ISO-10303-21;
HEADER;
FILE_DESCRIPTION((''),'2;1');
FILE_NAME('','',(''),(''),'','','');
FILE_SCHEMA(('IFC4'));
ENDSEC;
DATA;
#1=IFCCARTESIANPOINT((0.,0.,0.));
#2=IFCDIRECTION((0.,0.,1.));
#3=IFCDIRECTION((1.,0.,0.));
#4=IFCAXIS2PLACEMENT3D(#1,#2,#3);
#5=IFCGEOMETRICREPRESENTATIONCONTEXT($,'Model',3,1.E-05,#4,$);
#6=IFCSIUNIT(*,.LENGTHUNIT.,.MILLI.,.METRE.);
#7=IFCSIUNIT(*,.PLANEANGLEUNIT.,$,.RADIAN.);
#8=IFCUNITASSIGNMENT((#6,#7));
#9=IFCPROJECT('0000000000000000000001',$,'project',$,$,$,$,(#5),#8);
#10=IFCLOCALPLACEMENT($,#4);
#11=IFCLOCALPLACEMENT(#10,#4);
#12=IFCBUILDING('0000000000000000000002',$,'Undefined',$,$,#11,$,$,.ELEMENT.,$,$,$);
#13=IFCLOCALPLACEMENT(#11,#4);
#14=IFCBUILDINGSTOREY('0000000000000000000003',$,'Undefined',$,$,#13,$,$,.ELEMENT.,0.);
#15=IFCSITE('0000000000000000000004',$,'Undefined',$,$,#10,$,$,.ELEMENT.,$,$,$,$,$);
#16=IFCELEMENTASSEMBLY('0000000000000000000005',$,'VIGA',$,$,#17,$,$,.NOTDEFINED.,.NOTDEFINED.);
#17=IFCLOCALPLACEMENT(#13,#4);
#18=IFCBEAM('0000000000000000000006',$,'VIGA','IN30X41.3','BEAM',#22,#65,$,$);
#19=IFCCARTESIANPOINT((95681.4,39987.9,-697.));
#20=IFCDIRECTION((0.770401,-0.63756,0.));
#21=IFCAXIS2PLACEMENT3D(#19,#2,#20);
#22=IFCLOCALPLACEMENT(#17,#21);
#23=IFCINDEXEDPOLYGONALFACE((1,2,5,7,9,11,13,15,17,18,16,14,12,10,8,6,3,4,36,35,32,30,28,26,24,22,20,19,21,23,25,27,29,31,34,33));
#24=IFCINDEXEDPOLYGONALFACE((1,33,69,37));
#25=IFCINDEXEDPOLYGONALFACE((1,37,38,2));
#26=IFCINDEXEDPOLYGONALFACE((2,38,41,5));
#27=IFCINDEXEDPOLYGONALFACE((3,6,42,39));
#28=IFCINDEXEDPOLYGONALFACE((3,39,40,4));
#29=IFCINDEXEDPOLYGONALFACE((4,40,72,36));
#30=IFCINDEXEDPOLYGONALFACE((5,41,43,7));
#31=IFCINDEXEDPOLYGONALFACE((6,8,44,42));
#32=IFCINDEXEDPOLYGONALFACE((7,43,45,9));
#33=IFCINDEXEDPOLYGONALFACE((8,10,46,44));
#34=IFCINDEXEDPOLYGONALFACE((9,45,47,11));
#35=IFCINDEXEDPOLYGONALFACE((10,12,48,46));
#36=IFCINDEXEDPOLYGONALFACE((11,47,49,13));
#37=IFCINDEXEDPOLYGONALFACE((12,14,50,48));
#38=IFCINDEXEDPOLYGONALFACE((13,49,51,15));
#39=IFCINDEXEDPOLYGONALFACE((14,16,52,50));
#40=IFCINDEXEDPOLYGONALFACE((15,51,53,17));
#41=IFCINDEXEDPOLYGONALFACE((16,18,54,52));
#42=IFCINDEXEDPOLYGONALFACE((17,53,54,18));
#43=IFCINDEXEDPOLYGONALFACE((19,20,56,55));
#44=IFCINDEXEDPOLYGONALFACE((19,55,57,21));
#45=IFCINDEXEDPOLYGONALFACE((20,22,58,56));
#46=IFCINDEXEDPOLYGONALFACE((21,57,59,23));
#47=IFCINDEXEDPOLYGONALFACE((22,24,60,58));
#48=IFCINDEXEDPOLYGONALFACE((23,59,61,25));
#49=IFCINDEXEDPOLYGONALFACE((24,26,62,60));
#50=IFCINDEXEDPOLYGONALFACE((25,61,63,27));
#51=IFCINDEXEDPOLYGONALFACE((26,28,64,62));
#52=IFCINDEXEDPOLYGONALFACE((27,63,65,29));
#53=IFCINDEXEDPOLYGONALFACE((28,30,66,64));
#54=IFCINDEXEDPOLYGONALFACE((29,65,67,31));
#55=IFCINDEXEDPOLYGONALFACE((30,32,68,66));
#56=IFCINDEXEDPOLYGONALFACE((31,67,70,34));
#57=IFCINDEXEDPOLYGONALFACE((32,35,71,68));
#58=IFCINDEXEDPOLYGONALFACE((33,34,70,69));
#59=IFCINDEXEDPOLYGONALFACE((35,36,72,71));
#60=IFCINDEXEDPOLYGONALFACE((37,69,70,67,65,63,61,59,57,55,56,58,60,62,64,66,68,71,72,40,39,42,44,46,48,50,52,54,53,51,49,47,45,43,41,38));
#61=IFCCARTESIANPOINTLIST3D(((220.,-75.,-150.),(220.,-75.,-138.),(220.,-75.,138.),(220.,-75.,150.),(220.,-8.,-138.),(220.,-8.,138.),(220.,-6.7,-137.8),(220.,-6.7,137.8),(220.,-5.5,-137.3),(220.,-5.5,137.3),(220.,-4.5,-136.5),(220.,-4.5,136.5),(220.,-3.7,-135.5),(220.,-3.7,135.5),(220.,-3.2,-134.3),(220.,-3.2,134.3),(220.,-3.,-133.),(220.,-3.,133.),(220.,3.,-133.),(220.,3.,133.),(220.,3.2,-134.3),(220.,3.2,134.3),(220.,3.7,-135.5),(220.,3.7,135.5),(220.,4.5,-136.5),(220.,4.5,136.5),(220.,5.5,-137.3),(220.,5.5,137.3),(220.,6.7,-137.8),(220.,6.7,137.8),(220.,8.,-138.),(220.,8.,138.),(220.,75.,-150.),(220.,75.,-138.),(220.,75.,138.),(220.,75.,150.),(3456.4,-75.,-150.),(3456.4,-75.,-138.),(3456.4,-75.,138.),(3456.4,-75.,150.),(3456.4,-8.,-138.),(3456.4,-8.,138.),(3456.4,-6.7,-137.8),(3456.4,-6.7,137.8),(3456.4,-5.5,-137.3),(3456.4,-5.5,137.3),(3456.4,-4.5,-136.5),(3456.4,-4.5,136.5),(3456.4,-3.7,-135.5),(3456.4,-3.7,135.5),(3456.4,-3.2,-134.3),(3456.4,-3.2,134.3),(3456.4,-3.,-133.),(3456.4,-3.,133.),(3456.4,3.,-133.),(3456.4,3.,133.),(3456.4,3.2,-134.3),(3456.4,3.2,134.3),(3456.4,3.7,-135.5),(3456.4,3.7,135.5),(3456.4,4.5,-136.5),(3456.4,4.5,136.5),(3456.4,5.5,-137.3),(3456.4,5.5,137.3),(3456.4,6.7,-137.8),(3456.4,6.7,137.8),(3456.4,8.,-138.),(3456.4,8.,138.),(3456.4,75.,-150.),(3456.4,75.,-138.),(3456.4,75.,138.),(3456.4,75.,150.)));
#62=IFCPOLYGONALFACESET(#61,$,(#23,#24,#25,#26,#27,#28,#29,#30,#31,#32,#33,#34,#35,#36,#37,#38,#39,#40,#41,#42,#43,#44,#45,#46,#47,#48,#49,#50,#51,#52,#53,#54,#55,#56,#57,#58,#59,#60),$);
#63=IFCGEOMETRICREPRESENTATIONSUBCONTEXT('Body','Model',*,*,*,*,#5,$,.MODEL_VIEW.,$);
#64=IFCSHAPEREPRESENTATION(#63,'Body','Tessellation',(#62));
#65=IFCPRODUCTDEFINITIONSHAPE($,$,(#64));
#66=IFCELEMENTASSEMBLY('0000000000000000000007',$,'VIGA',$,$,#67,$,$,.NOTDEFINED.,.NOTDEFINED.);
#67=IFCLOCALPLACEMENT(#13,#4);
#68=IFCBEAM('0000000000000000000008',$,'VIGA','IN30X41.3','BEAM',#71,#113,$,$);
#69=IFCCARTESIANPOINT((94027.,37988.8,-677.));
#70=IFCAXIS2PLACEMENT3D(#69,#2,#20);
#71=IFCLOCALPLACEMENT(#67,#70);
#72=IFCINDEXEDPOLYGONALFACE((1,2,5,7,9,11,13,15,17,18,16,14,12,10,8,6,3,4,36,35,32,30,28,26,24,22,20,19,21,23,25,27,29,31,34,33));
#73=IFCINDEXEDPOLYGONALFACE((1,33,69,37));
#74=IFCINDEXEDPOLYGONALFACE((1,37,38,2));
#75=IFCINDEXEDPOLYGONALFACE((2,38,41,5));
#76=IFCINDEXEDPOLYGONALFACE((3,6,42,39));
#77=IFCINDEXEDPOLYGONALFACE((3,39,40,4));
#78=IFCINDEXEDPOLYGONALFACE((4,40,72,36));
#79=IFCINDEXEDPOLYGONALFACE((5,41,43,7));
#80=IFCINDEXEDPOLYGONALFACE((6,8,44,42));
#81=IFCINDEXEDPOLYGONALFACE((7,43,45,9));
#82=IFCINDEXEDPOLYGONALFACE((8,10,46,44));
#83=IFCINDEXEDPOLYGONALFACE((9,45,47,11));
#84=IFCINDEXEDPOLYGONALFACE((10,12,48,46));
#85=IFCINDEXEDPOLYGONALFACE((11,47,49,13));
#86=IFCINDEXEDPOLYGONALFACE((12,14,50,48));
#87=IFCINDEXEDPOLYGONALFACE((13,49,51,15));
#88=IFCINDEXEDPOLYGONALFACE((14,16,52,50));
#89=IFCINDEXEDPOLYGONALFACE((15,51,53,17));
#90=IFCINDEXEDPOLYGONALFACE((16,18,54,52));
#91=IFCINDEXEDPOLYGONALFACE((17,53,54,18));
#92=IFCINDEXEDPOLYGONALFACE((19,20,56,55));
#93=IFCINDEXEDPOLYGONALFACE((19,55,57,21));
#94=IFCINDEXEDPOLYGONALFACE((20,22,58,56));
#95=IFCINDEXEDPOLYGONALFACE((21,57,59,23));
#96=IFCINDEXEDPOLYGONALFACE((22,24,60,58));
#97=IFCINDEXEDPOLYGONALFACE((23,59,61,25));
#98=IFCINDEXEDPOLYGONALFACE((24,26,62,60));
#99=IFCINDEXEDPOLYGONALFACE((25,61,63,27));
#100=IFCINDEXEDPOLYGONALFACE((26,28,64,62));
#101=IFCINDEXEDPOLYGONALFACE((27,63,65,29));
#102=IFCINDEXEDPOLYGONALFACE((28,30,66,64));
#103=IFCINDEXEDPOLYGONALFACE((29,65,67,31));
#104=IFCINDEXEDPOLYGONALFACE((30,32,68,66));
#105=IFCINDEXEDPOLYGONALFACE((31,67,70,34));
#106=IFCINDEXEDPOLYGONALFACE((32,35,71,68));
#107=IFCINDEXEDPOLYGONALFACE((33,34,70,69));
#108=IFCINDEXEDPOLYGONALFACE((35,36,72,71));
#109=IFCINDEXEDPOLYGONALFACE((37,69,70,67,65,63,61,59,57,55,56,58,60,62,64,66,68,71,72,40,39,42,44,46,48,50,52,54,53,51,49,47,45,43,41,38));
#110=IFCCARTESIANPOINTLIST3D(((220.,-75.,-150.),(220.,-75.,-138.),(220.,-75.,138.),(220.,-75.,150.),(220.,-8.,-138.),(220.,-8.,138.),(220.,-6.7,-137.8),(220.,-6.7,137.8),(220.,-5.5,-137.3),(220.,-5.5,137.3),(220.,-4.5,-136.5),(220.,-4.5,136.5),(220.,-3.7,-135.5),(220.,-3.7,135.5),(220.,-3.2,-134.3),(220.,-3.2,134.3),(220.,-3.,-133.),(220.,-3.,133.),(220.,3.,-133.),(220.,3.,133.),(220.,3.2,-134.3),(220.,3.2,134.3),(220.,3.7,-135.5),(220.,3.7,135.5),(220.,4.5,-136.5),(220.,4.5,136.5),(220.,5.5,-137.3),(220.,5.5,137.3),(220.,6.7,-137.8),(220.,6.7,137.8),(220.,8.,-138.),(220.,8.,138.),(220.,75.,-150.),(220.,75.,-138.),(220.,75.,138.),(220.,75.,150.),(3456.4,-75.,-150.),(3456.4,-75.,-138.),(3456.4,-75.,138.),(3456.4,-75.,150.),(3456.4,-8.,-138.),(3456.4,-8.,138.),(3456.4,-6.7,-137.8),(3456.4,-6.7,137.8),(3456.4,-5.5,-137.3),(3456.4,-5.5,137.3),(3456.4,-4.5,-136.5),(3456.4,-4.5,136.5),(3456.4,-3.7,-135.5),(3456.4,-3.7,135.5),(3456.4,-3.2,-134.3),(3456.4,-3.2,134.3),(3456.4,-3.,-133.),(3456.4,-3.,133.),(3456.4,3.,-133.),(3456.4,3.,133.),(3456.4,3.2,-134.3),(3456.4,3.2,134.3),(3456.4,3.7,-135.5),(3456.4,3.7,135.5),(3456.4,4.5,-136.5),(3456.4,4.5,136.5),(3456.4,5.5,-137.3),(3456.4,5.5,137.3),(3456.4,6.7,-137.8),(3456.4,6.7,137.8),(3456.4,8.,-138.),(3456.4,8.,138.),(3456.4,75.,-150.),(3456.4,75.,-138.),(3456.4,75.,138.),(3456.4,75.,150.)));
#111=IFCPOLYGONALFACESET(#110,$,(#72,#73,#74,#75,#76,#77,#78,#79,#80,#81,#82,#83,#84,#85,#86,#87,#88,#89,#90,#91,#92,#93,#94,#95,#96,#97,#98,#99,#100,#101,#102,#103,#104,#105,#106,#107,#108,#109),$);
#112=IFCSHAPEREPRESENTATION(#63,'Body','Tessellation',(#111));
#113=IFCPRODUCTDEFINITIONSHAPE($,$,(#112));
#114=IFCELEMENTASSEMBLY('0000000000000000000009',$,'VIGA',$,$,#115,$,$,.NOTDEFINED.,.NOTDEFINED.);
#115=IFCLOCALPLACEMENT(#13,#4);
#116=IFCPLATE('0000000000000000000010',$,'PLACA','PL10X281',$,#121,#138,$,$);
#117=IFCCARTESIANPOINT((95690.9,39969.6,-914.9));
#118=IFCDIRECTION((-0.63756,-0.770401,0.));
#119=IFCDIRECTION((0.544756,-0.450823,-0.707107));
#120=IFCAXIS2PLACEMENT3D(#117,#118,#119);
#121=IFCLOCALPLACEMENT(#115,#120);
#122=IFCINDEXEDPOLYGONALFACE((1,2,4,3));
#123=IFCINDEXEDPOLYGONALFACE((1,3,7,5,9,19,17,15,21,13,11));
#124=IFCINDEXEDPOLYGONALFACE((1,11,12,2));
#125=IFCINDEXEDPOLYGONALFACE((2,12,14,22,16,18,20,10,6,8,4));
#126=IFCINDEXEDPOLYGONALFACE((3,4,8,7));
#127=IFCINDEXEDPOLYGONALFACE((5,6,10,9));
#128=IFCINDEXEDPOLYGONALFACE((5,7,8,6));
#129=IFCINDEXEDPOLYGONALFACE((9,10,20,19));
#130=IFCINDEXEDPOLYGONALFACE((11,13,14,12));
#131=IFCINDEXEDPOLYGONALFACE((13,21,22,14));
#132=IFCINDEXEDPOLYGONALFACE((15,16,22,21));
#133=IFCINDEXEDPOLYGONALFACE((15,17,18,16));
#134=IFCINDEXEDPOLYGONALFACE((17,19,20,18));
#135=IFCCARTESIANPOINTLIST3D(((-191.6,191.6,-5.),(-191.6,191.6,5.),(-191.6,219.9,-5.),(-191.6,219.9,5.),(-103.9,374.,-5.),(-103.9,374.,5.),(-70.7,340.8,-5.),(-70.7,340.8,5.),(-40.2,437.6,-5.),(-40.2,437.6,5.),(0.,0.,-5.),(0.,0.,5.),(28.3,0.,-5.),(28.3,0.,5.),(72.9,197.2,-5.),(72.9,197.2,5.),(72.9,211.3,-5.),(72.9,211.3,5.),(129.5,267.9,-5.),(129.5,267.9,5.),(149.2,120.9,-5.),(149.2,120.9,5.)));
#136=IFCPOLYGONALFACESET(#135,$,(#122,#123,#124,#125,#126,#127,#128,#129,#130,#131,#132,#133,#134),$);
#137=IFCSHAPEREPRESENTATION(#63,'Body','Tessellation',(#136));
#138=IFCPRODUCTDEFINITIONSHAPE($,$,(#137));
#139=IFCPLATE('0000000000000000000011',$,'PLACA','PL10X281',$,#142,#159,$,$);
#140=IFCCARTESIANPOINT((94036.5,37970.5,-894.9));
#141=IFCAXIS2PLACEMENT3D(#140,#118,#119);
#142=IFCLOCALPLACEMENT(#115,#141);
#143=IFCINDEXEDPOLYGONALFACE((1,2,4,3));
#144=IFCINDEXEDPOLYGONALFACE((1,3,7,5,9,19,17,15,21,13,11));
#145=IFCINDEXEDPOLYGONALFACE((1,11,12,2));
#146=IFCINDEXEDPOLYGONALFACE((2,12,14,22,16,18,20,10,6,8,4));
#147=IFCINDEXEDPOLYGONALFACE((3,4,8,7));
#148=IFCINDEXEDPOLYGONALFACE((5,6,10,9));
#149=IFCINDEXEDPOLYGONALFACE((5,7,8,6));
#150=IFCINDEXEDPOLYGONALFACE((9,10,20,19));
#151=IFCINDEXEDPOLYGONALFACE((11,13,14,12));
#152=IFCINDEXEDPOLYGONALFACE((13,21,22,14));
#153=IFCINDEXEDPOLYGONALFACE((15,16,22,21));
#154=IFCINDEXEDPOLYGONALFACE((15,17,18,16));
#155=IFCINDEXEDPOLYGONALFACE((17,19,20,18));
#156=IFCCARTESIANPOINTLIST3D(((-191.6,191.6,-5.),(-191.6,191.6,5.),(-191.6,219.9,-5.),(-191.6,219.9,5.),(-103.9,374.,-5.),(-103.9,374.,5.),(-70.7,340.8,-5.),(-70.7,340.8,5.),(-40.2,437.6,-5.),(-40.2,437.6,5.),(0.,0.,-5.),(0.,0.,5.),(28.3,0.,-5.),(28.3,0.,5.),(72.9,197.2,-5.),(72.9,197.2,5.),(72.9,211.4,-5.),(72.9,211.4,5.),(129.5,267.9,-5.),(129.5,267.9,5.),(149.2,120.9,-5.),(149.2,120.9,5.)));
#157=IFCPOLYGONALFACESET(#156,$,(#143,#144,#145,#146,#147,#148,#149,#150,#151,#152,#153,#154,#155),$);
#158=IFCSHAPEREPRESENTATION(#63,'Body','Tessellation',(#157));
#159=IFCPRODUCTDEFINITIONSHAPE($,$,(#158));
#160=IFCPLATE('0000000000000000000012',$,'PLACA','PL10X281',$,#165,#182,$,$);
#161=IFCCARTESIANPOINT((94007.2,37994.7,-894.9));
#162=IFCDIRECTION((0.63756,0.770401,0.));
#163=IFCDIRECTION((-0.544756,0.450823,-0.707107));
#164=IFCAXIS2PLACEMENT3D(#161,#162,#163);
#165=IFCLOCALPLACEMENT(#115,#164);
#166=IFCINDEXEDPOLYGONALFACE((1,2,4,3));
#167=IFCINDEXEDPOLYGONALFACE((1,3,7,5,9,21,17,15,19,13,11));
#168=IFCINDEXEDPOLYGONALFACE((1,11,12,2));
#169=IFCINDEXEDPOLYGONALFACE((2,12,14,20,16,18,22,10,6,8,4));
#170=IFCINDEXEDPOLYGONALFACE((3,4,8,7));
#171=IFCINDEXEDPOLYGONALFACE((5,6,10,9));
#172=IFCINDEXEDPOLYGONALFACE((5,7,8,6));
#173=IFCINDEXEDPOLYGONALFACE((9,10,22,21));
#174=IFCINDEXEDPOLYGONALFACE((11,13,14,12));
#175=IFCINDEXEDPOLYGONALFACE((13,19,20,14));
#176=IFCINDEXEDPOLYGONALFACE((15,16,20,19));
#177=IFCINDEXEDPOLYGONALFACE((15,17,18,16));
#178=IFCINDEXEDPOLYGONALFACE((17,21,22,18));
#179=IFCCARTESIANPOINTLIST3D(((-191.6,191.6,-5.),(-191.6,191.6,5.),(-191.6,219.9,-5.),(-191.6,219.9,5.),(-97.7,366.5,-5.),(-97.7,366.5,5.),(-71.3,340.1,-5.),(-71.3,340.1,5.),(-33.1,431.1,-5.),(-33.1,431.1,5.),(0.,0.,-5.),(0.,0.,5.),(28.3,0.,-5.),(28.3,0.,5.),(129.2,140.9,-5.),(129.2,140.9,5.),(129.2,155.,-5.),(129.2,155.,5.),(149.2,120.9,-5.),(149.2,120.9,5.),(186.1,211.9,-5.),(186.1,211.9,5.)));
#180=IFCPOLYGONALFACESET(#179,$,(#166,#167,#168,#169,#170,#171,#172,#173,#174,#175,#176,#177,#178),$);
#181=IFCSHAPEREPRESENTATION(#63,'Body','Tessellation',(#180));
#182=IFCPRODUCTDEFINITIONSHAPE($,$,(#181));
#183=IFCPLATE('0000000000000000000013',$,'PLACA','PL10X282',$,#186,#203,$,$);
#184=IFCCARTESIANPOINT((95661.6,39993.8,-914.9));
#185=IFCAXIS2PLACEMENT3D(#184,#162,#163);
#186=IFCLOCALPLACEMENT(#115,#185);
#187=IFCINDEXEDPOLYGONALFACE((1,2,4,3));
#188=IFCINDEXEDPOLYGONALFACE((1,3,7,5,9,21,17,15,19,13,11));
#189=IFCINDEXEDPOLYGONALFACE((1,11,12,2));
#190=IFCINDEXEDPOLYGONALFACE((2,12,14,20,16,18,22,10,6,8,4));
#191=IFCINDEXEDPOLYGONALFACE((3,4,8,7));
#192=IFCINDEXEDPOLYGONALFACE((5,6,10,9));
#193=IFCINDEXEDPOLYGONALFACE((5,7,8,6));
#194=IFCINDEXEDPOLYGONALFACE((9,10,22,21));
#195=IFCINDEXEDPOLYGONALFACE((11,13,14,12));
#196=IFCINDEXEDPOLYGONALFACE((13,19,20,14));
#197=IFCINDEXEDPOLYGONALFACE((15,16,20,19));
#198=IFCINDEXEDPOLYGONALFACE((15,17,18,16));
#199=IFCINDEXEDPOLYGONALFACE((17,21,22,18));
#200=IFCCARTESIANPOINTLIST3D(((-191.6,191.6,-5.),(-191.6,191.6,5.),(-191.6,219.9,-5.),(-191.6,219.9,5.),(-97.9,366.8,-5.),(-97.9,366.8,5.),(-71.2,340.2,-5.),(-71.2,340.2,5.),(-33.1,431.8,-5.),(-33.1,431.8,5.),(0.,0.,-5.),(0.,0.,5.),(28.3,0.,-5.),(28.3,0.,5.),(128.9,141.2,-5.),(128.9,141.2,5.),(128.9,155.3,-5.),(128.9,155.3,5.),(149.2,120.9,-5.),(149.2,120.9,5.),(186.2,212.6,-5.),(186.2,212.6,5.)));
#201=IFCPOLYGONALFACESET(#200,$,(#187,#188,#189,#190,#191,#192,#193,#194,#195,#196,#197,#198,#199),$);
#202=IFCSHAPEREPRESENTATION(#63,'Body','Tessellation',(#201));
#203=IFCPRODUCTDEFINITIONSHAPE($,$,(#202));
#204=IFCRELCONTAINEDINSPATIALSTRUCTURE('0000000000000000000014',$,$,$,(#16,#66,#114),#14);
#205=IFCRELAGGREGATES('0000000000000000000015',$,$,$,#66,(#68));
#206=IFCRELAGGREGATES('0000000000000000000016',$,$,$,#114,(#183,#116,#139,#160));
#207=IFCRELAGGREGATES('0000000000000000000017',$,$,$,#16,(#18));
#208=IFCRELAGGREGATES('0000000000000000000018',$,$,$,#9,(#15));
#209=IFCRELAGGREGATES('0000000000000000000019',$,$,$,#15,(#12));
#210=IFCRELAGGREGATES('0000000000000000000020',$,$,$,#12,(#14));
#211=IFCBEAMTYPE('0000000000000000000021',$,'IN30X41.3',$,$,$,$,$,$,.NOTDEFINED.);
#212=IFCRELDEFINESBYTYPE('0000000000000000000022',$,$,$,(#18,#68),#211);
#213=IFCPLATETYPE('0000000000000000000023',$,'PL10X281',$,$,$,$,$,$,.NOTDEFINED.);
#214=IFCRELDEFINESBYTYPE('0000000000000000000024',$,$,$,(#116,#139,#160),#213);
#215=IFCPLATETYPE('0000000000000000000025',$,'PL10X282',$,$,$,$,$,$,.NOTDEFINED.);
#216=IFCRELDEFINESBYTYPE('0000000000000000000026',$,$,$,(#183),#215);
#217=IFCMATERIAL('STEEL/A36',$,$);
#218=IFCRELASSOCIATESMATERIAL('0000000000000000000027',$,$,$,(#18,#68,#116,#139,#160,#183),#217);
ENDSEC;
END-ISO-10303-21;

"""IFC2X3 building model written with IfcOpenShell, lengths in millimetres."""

from ifc_helpers import new_model, si_unit, frame, origin_with_axes, origin_2d_with_axis, place, context, subcontext, project, spatial, polyline, i_section, outline, extrude, clip, halfspace, material, type_object, element, aggregate, save


model = new_model("IFC2X3")

# Units and contexts
model_context = context("Model", 3, precision=1e-05, world=origin_with_axes())
body_context = subcontext(model_context, "Body", "Model", "MODEL_VIEW")
ifc_project = project(units=[si_unit("LENGTHUNIT", "METRE", prefix="MILLI"), si_unit("PLANEANGLEUNIT", "RADIAN")], contexts=[model_context])

# Site, building, storey
site_placement = place(None, origin_with_axes())
site = spatial("IfcSite", under=ifc_project, at=site_placement, Name="Undefined", CompositionType="ELEMENT")
building_placement = place(site_placement, origin_with_axes())
building = spatial("IfcBuilding", under=site, at=building_placement, Name="Undefined", CompositionType="ELEMENT")
storey_placement = place(building_placement, origin_with_axes())
storey = spatial("IfcBuildingStorey", under=building, at=storey_placement, Name="Undefined", CompositionType="ELEMENT", Elevation=0.0)

# Shared definitions
ifc_material_1 = material(Name="STEEL/A36")

# Element assemblies, beams
assembly_1_placement = place(storey_placement, origin_with_axes())
assembly_1 = element("IfcElementAssembly", 1, at=assembly_1_placement, inside=storey, Name="VIGA", AssemblyPlace="NOTDEFINED", PredefinedType="NOTDEFINED")
beam_type_1 = type_object("IfcBeamType", Name="IN30X41.3", PredefinedType="NOTDEFINED")
beam_1_placement = place(assembly_1_placement, frame((95681.4, 39987.9, -697.0), z_axis=(0.0, 0.0, 1.0), x_axis=(0.770401, -0.63756, 0.0)))
beam_1 = element("IfcBeam", 2, at=beam_1_placement, type_object=beam_type_1, material=ifc_material_1, Name="VIGA", Description="IN30X41.3", ObjectType="BEAM", context=body_context, shape_type="Clipping", body=[
    clip(extrude(i_section(OverallWidth=150.0, OverallDepth=300.0, WebThickness=6.0, FlangeThickness=12.0, FilletRadius=5.0, at=origin_2d_with_axis()), frame((3456.4, 0.0, 0.0), z_axis=(-1.0, 0.0, 0.0), x_axis=(0.0, -1.0, 0.0)), (0.0, 0.0, 1.0), 3456.4), halfspace(frame((220.0, 0.0, 250.0), z_axis=(-1.0, 0.0, 0.0), x_axis=(0.0, -1.0, 0.0)), False)),
])
assembly_2_placement = place(storey_placement, origin_with_axes())
assembly_2 = element("IfcElementAssembly", 3, at=assembly_2_placement, inside=storey, Name="VIGA", AssemblyPlace="NOTDEFINED", PredefinedType="NOTDEFINED")
beam_2_placement = place(assembly_2_placement, frame((94027.0, 37988.8, -677.0), z_axis=(0.0, 0.0, 1.0), x_axis=(0.770401, -0.63756, 0.0)))
beam_2 = element("IfcBeam", 4, at=beam_2_placement, type_object=beam_type_1, material=ifc_material_1, Name="VIGA", Description="IN30X41.3", ObjectType="BEAM", context=body_context, shape_type="Clipping", body=[
    clip(extrude(i_section(OverallWidth=150.0, OverallDepth=300.0, WebThickness=6.0, FlangeThickness=12.0, FilletRadius=5.0, at=origin_2d_with_axis()), frame((3456.4, 0.0, 0.0), z_axis=(-1.0, 0.0, 0.0), x_axis=(0.0, -1.0, 0.0)), (0.0, 0.0, 1.0), 3456.4), halfspace(frame((220.0, 0.0, 250.0), z_axis=(-1.0, 0.0, 0.0), x_axis=(0.0, -1.0, 0.0)), False)),
])
aggregate(assembly_2, [beam_2])

# Element assembly
assembly_3_placement = place(storey_placement, origin_with_axes())
assembly_3 = element("IfcElementAssembly", 5, at=assembly_3_placement, inside=storey, Name="VIGA", AssemblyPlace="NOTDEFINED", PredefinedType="NOTDEFINED")

# Plates
plate_type_1 = type_object("IfcPlateType", Name="PL10X281", PredefinedType="NOTDEFINED")
plate_1_placement = place(assembly_3_placement, frame((95690.9, 39969.6, -914.9), z_axis=(-0.63756, -0.770401, 0.0), x_axis=(0.544756, -0.450823, -0.707107)))
plate_1 = element("IfcPlate", 6, at=plate_1_placement, type_object=plate_type_1, material=ifc_material_1, Name="PLACA", Description="PL10X281", context=body_context, shape_type="SweptSolid", body=[
    extrude(outline(polyline([(0.0, 0.0), (28.3, 0.0), (149.2, 120.9), (72.9, 197.2), (72.9, 211.3), (129.5, 267.9), (-40.2, 437.6), (-103.9, 374.0), (-70.7, 340.8), (-191.6, 219.9), (-191.6, 191.6), (0.0, 0.0)])), frame((0.0, 0.0, -5.0), z_axis=(0.0, 0.0, 1.0), x_axis=(1.0, 0.0, 0.0)), (0.0, 0.0, 1.0), 10.0),
])
plate_2_placement = place(assembly_3_placement, frame((94036.5, 37970.5, -894.9), z_axis=(-0.63756, -0.770401, 0.0), x_axis=(0.544756, -0.450823, -0.707107)))
plate_2 = element("IfcPlate", 7, at=plate_2_placement, type_object=plate_type_1, material=ifc_material_1, Name="PLACA", Description="PL10X281", context=body_context, shape_type="SweptSolid", body=[
    extrude(outline(polyline([(0.0, 0.0), (28.3, 0.0), (149.2, 120.9), (72.9, 197.2), (72.9, 211.4), (129.5, 267.9), (-40.2, 437.6), (-103.9, 374.0), (-70.7, 340.8), (-191.6, 219.9), (-191.6, 191.6), (0.0, 0.0)])), frame((0.0, 0.0, -5.0), z_axis=(0.0, 0.0, 1.0), x_axis=(1.0, 0.0, 0.0)), (0.0, 0.0, 1.0), 10.0),
])
plate_3_placement = place(assembly_3_placement, frame((94007.2, 37994.7, -894.9), z_axis=(0.63756, 0.770401, 0.0), x_axis=(-0.544756, 0.450823, -0.707107)))
plate_3 = element("IfcPlate", 8, at=plate_3_placement, type_object=plate_type_1, material=ifc_material_1, Name="PLACA", Description="PL10X281", context=body_context, shape_type="SweptSolid", body=[
    extrude(outline(polyline([(0.0, 0.0), (28.3, 0.0), (149.2, 120.9), (129.2, 140.9), (129.2, 155.0), (186.1, 211.9), (-33.1, 431.1), (-97.7, 366.5), (-71.3, 340.1), (-191.6, 219.9), (-191.6, 191.6), (0.0, 0.0)])), frame((0.0, 0.0, -5.0), z_axis=(0.0, 0.0, 1.0), x_axis=(1.0, 0.0, 0.0)), (0.0, 0.0, 1.0), 10.0),
])
plate_type_2 = type_object("IfcPlateType", Name="PL10X282", PredefinedType="NOTDEFINED")
plate_4_placement = place(assembly_3_placement, frame((95661.6, 39993.8, -914.9), z_axis=(0.63756, 0.770401, 0.0), x_axis=(-0.544756, 0.450823, -0.707107)))
plate_4 = element("IfcPlate", 9, at=plate_4_placement, type_object=plate_type_2, material=ifc_material_1, Name="PLACA", Description="PL10X282", context=body_context, shape_type="SweptSolid", body=[
    extrude(outline(polyline([(0.0, 0.0), (28.3, 0.0), (149.2, 120.9), (128.9, 141.2), (128.9, 155.3), (186.2, 212.6), (-33.1, 431.8), (-97.9, 366.8), (-71.2, 340.2), (-191.6, 219.9), (-191.6, 191.6), (0.0, 0.0)])), frame((0.0, 0.0, -5.0), z_axis=(0.0, 0.0, 1.0), x_axis=(1.0, 0.0, 0.0)), (0.0, 0.0, 1.0), 10.0),
])
aggregate(assembly_3, [plate_4, plate_1, plate_2, plate_3])

aggregate(assembly_1, [beam_1])

save(model, "model.ifc")
